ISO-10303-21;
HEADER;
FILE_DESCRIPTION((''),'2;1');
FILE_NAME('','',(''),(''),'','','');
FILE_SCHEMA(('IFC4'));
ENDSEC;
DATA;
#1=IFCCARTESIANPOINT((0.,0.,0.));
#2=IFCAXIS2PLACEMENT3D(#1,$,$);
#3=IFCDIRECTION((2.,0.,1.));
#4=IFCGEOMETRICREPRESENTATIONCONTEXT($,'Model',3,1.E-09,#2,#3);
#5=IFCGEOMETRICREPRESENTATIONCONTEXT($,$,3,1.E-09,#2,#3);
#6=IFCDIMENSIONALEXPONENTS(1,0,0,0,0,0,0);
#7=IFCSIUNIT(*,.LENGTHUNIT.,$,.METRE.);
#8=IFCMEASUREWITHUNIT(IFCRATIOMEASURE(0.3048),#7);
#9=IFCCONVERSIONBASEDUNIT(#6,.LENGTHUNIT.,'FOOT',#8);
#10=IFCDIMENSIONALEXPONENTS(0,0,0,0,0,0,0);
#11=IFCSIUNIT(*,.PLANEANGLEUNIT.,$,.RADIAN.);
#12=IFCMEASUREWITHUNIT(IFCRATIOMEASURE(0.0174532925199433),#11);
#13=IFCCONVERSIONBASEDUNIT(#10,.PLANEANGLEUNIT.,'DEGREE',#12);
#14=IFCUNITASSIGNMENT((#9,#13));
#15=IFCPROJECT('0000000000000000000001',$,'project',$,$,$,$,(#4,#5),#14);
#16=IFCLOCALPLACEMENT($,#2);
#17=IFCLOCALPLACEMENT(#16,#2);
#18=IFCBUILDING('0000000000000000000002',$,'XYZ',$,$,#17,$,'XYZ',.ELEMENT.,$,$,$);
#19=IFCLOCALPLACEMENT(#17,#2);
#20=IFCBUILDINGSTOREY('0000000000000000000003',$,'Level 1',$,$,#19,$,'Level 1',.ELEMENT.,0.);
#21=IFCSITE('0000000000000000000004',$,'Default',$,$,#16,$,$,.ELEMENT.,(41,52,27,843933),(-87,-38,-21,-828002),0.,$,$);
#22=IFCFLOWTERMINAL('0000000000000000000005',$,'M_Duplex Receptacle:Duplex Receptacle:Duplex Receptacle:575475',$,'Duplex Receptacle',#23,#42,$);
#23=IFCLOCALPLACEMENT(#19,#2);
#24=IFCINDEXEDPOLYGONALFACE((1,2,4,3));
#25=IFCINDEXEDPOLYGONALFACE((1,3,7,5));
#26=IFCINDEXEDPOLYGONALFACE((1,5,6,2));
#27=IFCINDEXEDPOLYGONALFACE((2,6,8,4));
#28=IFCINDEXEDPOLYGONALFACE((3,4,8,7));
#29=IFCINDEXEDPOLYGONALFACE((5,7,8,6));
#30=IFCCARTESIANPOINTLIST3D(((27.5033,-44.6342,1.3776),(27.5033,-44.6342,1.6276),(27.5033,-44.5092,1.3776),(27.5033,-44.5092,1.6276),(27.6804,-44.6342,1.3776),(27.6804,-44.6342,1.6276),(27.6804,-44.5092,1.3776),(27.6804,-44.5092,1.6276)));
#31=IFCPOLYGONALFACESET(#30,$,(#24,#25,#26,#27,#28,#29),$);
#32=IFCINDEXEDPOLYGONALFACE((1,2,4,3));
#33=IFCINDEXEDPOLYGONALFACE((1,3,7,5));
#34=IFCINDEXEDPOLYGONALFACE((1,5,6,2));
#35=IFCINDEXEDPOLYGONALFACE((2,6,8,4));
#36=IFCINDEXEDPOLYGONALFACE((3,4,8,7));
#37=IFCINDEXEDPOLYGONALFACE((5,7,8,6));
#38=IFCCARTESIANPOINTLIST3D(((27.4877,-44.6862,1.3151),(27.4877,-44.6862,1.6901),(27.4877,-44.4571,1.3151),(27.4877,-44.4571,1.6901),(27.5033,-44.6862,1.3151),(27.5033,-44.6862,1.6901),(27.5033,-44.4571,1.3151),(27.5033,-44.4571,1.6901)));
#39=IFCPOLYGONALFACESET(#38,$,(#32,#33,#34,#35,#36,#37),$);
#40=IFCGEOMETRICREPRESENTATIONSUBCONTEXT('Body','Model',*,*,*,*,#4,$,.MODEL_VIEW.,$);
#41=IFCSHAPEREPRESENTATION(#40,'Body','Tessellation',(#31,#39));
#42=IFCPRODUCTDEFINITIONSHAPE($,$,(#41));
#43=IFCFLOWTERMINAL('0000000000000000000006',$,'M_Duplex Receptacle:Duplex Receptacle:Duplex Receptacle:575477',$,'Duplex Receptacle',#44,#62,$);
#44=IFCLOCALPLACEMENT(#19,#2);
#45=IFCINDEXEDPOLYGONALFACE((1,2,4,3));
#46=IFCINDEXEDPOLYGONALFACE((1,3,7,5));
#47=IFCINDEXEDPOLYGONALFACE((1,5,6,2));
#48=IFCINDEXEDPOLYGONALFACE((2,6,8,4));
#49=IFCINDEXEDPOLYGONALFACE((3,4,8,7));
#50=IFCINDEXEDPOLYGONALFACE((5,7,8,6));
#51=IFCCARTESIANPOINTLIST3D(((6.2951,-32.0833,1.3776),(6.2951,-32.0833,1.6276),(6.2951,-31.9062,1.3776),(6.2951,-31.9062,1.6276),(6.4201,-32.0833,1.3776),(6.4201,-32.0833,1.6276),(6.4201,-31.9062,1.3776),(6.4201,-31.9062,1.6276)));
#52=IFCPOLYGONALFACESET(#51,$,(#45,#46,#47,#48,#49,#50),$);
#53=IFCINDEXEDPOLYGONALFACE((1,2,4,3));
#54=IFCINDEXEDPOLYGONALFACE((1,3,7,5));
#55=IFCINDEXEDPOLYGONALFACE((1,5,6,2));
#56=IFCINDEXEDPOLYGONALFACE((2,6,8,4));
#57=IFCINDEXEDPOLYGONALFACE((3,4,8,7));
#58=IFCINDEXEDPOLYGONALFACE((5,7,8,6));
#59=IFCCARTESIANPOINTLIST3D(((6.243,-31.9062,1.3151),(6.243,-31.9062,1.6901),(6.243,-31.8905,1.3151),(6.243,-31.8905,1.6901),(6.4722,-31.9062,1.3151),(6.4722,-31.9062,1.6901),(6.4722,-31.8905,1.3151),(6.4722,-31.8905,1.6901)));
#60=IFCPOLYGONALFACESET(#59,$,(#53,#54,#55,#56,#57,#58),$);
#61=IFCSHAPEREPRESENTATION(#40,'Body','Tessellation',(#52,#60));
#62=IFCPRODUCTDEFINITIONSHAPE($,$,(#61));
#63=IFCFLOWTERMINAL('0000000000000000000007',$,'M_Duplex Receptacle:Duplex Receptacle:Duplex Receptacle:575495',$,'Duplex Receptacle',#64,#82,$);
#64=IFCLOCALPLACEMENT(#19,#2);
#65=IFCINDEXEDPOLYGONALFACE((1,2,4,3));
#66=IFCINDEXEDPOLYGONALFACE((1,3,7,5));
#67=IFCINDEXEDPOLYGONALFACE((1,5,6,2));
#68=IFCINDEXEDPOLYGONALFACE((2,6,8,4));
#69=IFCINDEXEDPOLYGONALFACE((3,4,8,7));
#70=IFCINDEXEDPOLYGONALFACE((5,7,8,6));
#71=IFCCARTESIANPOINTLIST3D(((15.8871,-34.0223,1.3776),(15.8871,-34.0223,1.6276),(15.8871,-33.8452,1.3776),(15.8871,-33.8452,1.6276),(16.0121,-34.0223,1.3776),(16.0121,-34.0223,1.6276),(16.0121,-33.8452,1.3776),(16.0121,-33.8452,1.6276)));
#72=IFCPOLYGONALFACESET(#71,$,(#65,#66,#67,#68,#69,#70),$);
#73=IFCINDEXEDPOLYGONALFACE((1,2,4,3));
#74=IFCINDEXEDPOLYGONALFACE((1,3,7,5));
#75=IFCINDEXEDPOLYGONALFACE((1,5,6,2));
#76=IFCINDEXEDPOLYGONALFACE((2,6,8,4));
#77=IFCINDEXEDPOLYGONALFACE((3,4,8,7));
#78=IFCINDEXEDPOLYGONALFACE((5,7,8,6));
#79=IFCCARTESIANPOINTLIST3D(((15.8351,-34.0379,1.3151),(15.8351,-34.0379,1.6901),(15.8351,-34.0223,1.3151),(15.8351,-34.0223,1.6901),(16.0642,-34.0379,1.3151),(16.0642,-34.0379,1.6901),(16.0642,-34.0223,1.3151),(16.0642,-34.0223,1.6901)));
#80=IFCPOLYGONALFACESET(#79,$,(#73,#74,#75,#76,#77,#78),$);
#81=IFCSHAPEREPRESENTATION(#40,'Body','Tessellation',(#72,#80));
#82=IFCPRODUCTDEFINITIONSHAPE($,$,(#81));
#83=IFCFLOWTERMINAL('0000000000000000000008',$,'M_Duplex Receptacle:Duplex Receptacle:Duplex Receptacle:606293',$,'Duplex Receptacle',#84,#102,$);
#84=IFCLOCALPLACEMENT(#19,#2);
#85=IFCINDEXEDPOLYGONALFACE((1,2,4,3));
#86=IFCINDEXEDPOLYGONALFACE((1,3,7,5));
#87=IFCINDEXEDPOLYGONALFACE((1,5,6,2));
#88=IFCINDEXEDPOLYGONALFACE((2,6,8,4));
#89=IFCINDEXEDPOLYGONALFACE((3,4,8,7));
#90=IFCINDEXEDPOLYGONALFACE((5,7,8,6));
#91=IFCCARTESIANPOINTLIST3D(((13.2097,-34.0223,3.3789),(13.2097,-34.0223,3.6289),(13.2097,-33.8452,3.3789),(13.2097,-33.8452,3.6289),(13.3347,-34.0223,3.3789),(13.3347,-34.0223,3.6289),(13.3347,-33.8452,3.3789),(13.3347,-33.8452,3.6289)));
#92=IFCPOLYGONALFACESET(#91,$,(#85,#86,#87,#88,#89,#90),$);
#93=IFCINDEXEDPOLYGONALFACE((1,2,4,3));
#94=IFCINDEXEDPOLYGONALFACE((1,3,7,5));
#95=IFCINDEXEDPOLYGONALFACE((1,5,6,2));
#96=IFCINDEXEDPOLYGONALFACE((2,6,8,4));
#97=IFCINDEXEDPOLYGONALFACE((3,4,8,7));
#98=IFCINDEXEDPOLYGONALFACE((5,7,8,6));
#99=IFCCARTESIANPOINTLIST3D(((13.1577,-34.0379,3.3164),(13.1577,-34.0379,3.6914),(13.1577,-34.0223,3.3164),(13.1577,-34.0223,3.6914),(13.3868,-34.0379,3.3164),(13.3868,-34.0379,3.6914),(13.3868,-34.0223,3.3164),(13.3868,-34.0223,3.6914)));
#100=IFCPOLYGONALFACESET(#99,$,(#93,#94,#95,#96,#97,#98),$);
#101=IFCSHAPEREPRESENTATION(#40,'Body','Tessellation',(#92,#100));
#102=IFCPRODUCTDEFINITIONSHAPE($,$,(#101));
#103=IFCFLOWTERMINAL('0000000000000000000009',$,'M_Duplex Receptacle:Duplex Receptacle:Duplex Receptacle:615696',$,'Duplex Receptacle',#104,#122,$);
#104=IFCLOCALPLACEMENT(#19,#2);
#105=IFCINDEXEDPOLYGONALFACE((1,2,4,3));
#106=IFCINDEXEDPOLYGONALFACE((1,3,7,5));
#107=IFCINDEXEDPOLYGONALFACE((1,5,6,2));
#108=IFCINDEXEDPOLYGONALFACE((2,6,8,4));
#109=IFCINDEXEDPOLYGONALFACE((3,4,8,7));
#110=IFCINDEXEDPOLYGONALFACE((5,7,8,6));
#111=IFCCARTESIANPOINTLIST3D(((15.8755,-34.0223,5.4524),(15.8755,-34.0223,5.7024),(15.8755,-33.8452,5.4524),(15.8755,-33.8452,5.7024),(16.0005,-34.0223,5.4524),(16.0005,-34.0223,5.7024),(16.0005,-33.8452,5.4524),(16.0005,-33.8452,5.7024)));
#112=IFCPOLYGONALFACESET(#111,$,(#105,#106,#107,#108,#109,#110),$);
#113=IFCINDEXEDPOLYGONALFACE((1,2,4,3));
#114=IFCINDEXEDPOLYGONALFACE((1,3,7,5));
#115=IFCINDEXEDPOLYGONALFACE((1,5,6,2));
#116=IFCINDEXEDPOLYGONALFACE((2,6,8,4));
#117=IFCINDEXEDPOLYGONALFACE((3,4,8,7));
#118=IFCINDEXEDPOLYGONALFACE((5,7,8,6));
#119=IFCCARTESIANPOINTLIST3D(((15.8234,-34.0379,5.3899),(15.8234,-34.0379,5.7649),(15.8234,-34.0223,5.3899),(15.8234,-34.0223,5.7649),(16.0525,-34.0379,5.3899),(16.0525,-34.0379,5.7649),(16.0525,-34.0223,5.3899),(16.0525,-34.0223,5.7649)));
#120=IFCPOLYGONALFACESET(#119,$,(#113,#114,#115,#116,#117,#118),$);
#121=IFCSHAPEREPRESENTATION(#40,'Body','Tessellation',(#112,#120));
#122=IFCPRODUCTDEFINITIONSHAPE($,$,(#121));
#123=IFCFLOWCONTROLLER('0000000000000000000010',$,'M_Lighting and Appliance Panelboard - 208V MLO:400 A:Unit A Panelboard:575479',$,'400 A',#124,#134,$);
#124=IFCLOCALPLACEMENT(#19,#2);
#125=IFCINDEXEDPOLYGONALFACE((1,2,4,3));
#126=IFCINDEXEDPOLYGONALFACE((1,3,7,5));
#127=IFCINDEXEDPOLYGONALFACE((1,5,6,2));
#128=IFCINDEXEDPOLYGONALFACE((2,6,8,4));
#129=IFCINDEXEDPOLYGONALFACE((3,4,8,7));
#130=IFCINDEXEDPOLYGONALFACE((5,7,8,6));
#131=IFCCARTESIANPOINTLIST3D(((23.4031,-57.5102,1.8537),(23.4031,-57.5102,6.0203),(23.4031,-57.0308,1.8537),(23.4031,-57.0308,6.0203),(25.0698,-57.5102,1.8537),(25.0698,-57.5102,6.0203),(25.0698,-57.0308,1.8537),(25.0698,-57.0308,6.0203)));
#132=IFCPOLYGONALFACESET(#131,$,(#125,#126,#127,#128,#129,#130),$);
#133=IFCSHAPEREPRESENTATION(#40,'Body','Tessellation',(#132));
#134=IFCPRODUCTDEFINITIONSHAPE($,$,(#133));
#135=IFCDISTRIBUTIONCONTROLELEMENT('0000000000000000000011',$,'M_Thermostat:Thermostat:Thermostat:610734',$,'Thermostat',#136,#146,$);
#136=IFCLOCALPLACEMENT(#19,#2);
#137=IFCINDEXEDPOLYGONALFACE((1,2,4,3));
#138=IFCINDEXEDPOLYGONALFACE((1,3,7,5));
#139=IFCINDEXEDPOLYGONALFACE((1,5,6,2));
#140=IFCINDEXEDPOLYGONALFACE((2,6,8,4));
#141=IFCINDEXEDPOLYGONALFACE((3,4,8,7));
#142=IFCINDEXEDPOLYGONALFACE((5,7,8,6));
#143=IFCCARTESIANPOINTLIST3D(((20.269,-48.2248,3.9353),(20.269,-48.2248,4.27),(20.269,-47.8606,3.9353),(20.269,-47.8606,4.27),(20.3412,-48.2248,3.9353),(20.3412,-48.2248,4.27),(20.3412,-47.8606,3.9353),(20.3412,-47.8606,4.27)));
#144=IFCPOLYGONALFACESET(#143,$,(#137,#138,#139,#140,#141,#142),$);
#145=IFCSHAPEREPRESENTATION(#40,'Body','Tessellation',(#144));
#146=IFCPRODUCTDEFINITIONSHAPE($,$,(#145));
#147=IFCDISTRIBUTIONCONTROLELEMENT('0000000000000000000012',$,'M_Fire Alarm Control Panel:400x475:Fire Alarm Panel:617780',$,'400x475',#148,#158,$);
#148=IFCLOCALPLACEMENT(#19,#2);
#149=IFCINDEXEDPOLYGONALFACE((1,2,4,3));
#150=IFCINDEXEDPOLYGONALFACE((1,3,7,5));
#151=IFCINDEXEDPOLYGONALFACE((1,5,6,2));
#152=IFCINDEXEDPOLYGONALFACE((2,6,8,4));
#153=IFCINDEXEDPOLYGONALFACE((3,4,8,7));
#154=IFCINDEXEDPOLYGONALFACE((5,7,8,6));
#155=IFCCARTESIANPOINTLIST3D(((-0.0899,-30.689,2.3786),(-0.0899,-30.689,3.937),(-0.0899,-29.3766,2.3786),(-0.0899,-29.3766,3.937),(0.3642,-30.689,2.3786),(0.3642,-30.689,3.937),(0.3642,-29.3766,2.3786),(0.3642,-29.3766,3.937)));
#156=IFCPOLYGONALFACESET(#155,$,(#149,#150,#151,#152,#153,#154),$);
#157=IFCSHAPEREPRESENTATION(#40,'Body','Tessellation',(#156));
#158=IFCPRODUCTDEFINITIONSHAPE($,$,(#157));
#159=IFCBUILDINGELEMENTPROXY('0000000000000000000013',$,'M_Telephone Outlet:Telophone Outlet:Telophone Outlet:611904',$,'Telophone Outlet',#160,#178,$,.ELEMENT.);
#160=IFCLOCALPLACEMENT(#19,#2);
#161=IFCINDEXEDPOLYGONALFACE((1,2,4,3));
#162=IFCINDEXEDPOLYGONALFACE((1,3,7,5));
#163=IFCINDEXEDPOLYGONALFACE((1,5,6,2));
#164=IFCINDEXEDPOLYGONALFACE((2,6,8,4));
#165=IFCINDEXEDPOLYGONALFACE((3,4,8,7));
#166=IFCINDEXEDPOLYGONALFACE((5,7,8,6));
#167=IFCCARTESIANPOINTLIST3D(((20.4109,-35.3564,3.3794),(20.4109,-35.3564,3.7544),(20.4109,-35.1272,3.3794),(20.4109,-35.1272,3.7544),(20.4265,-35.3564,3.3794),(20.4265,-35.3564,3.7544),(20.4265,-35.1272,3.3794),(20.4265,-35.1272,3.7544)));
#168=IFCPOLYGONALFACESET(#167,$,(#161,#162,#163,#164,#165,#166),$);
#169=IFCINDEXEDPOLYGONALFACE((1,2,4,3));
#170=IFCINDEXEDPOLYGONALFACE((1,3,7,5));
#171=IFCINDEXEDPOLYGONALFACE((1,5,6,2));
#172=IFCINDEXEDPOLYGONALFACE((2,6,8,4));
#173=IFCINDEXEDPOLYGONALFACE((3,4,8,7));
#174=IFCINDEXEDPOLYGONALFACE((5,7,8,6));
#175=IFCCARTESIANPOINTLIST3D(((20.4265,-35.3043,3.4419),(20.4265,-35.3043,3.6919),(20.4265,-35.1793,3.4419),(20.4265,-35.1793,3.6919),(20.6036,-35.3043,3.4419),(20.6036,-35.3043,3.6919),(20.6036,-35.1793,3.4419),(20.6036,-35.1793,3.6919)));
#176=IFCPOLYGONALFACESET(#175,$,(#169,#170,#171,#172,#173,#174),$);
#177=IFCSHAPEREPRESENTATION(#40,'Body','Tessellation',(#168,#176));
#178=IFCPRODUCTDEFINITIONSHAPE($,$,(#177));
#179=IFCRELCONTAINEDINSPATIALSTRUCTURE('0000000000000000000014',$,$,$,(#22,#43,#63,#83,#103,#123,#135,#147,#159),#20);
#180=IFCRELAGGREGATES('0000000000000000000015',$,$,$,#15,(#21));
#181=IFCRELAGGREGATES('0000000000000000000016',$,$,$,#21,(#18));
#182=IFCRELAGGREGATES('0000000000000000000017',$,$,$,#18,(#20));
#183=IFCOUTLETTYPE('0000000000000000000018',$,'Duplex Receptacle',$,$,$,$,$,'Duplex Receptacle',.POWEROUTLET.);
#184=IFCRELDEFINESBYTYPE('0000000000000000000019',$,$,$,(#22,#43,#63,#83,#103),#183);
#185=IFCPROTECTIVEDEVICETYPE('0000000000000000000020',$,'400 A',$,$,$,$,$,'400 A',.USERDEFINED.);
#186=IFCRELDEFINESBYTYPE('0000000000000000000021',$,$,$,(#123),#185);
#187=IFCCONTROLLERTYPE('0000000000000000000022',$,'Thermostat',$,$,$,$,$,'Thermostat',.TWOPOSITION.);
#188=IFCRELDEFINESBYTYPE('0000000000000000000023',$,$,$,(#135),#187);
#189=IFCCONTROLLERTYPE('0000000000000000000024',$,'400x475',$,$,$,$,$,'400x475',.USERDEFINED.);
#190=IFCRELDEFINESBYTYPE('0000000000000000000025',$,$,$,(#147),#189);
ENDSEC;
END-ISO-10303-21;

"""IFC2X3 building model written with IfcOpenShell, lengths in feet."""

from ifc_helpers import new_model, entity, si_unit, converted_unit, direction, frame, frame_2d, origin, origin_2d_with_axis, place, context, subcontext, project, spatial, rectangle, extrude, source, transform, mapped, type_object, type_shapes, element, save


model = new_model("IFC2X3")

# Units and contexts
model_context = context("Model", 3, precision=1e-09, world=origin(), true_north=direction((2.0, 0.0, 1.0)))
context_of_model = context(None, 3, precision=1e-09, world=origin(), true_north=direction((2.0, 0.0, 1.0)))
body_context = subcontext(model_context, "Body", "Model", "MODEL_VIEW")
ifc_project = project(units=[converted_unit("LENGTHUNIT", "FOOT", entity("IfcRatioMeasure", 0.3048), si_unit("LENGTHUNIT", "METRE"), dimensions=[1, 0, 0, 0, 0, 0, 0]), converted_unit("PLANEANGLEUNIT", "DEGREE", entity("IfcRatioMeasure", 0.0174532925199433), si_unit("PLANEANGLEUNIT", "RADIAN"), dimensions=[0, 0, 0, 0, 0, 0, 0])], contexts=[model_context, context_of_model])

# Site, building, storey
site_placement = place(None, origin())
site = spatial("IfcSite", under=ifc_project, at=site_placement, Name="Default", CompositionType="ELEMENT", RefLatitude=(41, 52, 27, 843933), RefLongitude=(-87, -38, -21, -828002), RefElevation=0.0)
building_placement = place(site_placement, origin())
building = spatial("IfcBuilding", under=site, at=building_placement, Name="XYZ", LongName="XYZ", CompositionType="ELEMENT")
storey_placement = place(building_placement, origin())
storey = spatial("IfcBuildingStorey", under=building, at=storey_placement, Name="Level 1", LongName="Level 1", CompositionType="ELEMENT", Elevation=0.0)

# Flow terminals
outlet_type = type_object("IfcOutletType", Name="Duplex Receptacle", ElementType="Duplex Receptacle", PredefinedType="POWEROUTLET")
shared_shape_1 = source(origin(), body_context, "Body", "SweptSolid", [
    extrude(rectangle(XDim=0.125, YDim=0.25, at=origin_2d_with_axis()), frame((0.0, 0.0, -0.1771), z_axis=(0.0, 0.0, 1.0), x_axis=(-1.0, 0.0, 0.0)), (0.0, 0.0, 1.0), 0.1771),
    extrude(rectangle(XDim=0.2292, YDim=0.375, at=frame_2d((0.0, 0.0), x_axis=(1.0, 0.0))), frame((0.0, 0.0, 0.0), z_axis=(0.0, 0.0, 1.0), x_axis=(-1.0, 0.0, 0.0)), (0.0, 0.0, 1.0), 0.0156),
])
type_shapes(outlet_type, [shared_shape_1])
for number, where, z_axis, x_axis, name in (
    (1, (27.5033, -44.5717, 1.5026), (-1.0, 0.0, 0.0), (0.0, -1.0, 0.0), "M_Duplex Receptacle:Duplex Receptacle:Duplex Receptacle:575475"),
    (2, (6.3576, -31.9062, 1.5026), (0.0, 1.0, 0.0), (-1.0, 0.0, 0.0), "M_Duplex Receptacle:Duplex Receptacle:Duplex Receptacle:575477"),
    (3, (15.9496, -34.0223, 1.5026), (0.0, -1.0, 0.0), (1.0, 0.0, 0.0), "M_Duplex Receptacle:Duplex Receptacle:Duplex Receptacle:575495"),
    (4, (13.2722, -34.0223, 3.5039), (0.0, -1.0, 0.0), (1.0, 0.0, 0.0), "M_Duplex Receptacle:Duplex Receptacle:Duplex Receptacle:606293"),
    (5, (15.938, -34.0223, 5.5774), (0.0, -1.0, 0.0), (1.0, 0.0, 0.0), "M_Duplex Receptacle:Duplex Receptacle:Duplex Receptacle:615696"),
):
    element("IfcFlowTerminal", number, at=place(storey_placement, frame(where, z_axis=z_axis, x_axis=x_axis)), inside=storey, type_object=outlet_type, Name=name, ObjectType="Duplex Receptacle", context=body_context, shape_type="MappedRepresentation", body=[
        mapped(shared_shape_1, transform((0.0, 0.0, 0.0), scale=1.0)),
    ])

# Flow controller
protective_device_type = type_object("IfcProtectiveDeviceType", Name="400 A", ElementType="400 A", PredefinedType="USERDEFINED")
shared_shape_2 = source(origin(), body_context, "Body", "SweptSolid", [
    extrude(rectangle(XDim=1.6667, YDim=4.1667, at=origin_2d_with_axis()), frame((0.0, -1.375, -0.4793), z_axis=(0.0, 0.0, 1.0), x_axis=(-1.0, 0.0, 0.0)), (0.0, 0.0, 1.0), 0.4793),
])
type_shapes(protective_device_type, [shared_shape_2])
flow_controller_placement = place(storey_placement, frame((24.2364, -57.0308, 5.312), z_axis=(0.0, 1.0, 0.0), x_axis=(-1.0, 0.0, 0.0)))
element("IfcFlowController", 6, at=flow_controller_placement, inside=storey, type_object=protective_device_type, Name="M_Lighting and Appliance Panelboard - 208V MLO:400 A:Unit A Panelboard:575479", ObjectType="400 A", context=body_context, shape_type="MappedRepresentation", body=[
    mapped(shared_shape_2, transform((0.0, 0.0, 0.0), scale=1.0)),
])

# Distribution control elements
controller_type_1 = type_object("IfcControllerType", Name="Thermostat", ElementType="Thermostat", PredefinedType="TWOPOSITION")
shared_shape_3 = source(origin(), body_context, "Body", "SweptSolid", [
    extrude(rectangle(XDim=0.3346, YDim=0.3642, at=origin_2d_with_axis()), frame((0.0, -0.1673, 0.0), z_axis=(0.0, 0.0, 1.0), x_axis=(0.0, 1.0, 0.0)), (0.0, 0.0, 1.0), 0.0722),
])
type_shapes(controller_type_1, [shared_shape_3])
distribution_control_element_1_placement = place(storey_placement, frame((20.3412, -48.0427, 4.27), z_axis=(-1.0, 0.0, 0.0), x_axis=(0.0, -1.0, 0.0)))
element("IfcDistributionControlElement", 7, at=distribution_control_element_1_placement, inside=storey, type_object=controller_type_1, Name="M_Thermostat:Thermostat:Thermostat:610734", ObjectType="Thermostat", context=body_context, shape_type="MappedRepresentation", body=[
    mapped(shared_shape_3, transform((0.0, 0.0, 0.0), scale=1.0)),
])
controller_type_2 = type_object("IfcControllerType", Name="400x475", ElementType="400x475", PredefinedType="USERDEFINED")
shared_shape_4 = source(origin(), body_context, "Body", "SweptSolid", [
    extrude(rectangle(XDim=1.3123, YDim=1.5584, at=frame_2d((0.0, 0.0), x_axis=(1.0, 0.0))), frame((0.0014, -0.7792, -0.3642), z_axis=(0.0, 0.0, 1.0), x_axis=(-1.0, 0.0, 0.0)), (0.0, 0.0, 1.0), 0.4541),
])
type_shapes(controller_type_2, [shared_shape_4])
distribution_control_element_2_placement = place(storey_placement, frame((0.0, -30.0314, 3.937), z_axis=(-1.0, 0.0, 0.0), x_axis=(0.0, -1.0, 0.0)))
element("IfcDistributionControlElement", 8, at=distribution_control_element_2_placement, inside=storey, type_object=controller_type_2, Name="M_Fire Alarm Control Panel:400x475:Fire Alarm Panel:617780", ObjectType="400x475", context=body_context, shape_type="MappedRepresentation", body=[
    mapped(shared_shape_4, transform((0.0, 0.0, 0.0), scale=1.0)),
])

# Building element proxy
shared_shape_5 = source(origin(), body_context, "Body", "SweptSolid", [
    extrude(rectangle(XDim=0.2292, YDim=0.375, at=frame_2d((0.0, 0.0), x_axis=(1.0, 0.0))), frame((0.0, 0.0, 0.0), z_axis=(0.0, 0.0, 1.0), x_axis=(-1.0, 0.0, 0.0)), (0.0, 0.0, 1.0), 0.0156),
    extrude(rectangle(XDim=0.125, YDim=0.25, at=origin_2d_with_axis()), frame((0.0, 0.0, -0.1771), z_axis=(0.0, 0.0, 1.0), x_axis=(-1.0, 0.0, 0.0)), (0.0, 0.0, 1.0), 0.1771),
])
proxy_placement = place(storey_placement, frame((20.4265, -35.2418, 3.5669), z_axis=(-1.0, 0.0, 0.0), x_axis=(0.0, -1.0, 0.0)))
element("IfcBuildingElementProxy", 9, at=proxy_placement, inside=storey, Name="M_Telephone Outlet:Telophone Outlet:Telophone Outlet:611904", ObjectType="Telophone Outlet", CompositionType="ELEMENT", context=body_context, shape_type="MappedRepresentation", body=[
    mapped(shared_shape_5, transform((0.0, 0.0, 0.0), scale=1.0)),
])

save(model, "model.ifc")
